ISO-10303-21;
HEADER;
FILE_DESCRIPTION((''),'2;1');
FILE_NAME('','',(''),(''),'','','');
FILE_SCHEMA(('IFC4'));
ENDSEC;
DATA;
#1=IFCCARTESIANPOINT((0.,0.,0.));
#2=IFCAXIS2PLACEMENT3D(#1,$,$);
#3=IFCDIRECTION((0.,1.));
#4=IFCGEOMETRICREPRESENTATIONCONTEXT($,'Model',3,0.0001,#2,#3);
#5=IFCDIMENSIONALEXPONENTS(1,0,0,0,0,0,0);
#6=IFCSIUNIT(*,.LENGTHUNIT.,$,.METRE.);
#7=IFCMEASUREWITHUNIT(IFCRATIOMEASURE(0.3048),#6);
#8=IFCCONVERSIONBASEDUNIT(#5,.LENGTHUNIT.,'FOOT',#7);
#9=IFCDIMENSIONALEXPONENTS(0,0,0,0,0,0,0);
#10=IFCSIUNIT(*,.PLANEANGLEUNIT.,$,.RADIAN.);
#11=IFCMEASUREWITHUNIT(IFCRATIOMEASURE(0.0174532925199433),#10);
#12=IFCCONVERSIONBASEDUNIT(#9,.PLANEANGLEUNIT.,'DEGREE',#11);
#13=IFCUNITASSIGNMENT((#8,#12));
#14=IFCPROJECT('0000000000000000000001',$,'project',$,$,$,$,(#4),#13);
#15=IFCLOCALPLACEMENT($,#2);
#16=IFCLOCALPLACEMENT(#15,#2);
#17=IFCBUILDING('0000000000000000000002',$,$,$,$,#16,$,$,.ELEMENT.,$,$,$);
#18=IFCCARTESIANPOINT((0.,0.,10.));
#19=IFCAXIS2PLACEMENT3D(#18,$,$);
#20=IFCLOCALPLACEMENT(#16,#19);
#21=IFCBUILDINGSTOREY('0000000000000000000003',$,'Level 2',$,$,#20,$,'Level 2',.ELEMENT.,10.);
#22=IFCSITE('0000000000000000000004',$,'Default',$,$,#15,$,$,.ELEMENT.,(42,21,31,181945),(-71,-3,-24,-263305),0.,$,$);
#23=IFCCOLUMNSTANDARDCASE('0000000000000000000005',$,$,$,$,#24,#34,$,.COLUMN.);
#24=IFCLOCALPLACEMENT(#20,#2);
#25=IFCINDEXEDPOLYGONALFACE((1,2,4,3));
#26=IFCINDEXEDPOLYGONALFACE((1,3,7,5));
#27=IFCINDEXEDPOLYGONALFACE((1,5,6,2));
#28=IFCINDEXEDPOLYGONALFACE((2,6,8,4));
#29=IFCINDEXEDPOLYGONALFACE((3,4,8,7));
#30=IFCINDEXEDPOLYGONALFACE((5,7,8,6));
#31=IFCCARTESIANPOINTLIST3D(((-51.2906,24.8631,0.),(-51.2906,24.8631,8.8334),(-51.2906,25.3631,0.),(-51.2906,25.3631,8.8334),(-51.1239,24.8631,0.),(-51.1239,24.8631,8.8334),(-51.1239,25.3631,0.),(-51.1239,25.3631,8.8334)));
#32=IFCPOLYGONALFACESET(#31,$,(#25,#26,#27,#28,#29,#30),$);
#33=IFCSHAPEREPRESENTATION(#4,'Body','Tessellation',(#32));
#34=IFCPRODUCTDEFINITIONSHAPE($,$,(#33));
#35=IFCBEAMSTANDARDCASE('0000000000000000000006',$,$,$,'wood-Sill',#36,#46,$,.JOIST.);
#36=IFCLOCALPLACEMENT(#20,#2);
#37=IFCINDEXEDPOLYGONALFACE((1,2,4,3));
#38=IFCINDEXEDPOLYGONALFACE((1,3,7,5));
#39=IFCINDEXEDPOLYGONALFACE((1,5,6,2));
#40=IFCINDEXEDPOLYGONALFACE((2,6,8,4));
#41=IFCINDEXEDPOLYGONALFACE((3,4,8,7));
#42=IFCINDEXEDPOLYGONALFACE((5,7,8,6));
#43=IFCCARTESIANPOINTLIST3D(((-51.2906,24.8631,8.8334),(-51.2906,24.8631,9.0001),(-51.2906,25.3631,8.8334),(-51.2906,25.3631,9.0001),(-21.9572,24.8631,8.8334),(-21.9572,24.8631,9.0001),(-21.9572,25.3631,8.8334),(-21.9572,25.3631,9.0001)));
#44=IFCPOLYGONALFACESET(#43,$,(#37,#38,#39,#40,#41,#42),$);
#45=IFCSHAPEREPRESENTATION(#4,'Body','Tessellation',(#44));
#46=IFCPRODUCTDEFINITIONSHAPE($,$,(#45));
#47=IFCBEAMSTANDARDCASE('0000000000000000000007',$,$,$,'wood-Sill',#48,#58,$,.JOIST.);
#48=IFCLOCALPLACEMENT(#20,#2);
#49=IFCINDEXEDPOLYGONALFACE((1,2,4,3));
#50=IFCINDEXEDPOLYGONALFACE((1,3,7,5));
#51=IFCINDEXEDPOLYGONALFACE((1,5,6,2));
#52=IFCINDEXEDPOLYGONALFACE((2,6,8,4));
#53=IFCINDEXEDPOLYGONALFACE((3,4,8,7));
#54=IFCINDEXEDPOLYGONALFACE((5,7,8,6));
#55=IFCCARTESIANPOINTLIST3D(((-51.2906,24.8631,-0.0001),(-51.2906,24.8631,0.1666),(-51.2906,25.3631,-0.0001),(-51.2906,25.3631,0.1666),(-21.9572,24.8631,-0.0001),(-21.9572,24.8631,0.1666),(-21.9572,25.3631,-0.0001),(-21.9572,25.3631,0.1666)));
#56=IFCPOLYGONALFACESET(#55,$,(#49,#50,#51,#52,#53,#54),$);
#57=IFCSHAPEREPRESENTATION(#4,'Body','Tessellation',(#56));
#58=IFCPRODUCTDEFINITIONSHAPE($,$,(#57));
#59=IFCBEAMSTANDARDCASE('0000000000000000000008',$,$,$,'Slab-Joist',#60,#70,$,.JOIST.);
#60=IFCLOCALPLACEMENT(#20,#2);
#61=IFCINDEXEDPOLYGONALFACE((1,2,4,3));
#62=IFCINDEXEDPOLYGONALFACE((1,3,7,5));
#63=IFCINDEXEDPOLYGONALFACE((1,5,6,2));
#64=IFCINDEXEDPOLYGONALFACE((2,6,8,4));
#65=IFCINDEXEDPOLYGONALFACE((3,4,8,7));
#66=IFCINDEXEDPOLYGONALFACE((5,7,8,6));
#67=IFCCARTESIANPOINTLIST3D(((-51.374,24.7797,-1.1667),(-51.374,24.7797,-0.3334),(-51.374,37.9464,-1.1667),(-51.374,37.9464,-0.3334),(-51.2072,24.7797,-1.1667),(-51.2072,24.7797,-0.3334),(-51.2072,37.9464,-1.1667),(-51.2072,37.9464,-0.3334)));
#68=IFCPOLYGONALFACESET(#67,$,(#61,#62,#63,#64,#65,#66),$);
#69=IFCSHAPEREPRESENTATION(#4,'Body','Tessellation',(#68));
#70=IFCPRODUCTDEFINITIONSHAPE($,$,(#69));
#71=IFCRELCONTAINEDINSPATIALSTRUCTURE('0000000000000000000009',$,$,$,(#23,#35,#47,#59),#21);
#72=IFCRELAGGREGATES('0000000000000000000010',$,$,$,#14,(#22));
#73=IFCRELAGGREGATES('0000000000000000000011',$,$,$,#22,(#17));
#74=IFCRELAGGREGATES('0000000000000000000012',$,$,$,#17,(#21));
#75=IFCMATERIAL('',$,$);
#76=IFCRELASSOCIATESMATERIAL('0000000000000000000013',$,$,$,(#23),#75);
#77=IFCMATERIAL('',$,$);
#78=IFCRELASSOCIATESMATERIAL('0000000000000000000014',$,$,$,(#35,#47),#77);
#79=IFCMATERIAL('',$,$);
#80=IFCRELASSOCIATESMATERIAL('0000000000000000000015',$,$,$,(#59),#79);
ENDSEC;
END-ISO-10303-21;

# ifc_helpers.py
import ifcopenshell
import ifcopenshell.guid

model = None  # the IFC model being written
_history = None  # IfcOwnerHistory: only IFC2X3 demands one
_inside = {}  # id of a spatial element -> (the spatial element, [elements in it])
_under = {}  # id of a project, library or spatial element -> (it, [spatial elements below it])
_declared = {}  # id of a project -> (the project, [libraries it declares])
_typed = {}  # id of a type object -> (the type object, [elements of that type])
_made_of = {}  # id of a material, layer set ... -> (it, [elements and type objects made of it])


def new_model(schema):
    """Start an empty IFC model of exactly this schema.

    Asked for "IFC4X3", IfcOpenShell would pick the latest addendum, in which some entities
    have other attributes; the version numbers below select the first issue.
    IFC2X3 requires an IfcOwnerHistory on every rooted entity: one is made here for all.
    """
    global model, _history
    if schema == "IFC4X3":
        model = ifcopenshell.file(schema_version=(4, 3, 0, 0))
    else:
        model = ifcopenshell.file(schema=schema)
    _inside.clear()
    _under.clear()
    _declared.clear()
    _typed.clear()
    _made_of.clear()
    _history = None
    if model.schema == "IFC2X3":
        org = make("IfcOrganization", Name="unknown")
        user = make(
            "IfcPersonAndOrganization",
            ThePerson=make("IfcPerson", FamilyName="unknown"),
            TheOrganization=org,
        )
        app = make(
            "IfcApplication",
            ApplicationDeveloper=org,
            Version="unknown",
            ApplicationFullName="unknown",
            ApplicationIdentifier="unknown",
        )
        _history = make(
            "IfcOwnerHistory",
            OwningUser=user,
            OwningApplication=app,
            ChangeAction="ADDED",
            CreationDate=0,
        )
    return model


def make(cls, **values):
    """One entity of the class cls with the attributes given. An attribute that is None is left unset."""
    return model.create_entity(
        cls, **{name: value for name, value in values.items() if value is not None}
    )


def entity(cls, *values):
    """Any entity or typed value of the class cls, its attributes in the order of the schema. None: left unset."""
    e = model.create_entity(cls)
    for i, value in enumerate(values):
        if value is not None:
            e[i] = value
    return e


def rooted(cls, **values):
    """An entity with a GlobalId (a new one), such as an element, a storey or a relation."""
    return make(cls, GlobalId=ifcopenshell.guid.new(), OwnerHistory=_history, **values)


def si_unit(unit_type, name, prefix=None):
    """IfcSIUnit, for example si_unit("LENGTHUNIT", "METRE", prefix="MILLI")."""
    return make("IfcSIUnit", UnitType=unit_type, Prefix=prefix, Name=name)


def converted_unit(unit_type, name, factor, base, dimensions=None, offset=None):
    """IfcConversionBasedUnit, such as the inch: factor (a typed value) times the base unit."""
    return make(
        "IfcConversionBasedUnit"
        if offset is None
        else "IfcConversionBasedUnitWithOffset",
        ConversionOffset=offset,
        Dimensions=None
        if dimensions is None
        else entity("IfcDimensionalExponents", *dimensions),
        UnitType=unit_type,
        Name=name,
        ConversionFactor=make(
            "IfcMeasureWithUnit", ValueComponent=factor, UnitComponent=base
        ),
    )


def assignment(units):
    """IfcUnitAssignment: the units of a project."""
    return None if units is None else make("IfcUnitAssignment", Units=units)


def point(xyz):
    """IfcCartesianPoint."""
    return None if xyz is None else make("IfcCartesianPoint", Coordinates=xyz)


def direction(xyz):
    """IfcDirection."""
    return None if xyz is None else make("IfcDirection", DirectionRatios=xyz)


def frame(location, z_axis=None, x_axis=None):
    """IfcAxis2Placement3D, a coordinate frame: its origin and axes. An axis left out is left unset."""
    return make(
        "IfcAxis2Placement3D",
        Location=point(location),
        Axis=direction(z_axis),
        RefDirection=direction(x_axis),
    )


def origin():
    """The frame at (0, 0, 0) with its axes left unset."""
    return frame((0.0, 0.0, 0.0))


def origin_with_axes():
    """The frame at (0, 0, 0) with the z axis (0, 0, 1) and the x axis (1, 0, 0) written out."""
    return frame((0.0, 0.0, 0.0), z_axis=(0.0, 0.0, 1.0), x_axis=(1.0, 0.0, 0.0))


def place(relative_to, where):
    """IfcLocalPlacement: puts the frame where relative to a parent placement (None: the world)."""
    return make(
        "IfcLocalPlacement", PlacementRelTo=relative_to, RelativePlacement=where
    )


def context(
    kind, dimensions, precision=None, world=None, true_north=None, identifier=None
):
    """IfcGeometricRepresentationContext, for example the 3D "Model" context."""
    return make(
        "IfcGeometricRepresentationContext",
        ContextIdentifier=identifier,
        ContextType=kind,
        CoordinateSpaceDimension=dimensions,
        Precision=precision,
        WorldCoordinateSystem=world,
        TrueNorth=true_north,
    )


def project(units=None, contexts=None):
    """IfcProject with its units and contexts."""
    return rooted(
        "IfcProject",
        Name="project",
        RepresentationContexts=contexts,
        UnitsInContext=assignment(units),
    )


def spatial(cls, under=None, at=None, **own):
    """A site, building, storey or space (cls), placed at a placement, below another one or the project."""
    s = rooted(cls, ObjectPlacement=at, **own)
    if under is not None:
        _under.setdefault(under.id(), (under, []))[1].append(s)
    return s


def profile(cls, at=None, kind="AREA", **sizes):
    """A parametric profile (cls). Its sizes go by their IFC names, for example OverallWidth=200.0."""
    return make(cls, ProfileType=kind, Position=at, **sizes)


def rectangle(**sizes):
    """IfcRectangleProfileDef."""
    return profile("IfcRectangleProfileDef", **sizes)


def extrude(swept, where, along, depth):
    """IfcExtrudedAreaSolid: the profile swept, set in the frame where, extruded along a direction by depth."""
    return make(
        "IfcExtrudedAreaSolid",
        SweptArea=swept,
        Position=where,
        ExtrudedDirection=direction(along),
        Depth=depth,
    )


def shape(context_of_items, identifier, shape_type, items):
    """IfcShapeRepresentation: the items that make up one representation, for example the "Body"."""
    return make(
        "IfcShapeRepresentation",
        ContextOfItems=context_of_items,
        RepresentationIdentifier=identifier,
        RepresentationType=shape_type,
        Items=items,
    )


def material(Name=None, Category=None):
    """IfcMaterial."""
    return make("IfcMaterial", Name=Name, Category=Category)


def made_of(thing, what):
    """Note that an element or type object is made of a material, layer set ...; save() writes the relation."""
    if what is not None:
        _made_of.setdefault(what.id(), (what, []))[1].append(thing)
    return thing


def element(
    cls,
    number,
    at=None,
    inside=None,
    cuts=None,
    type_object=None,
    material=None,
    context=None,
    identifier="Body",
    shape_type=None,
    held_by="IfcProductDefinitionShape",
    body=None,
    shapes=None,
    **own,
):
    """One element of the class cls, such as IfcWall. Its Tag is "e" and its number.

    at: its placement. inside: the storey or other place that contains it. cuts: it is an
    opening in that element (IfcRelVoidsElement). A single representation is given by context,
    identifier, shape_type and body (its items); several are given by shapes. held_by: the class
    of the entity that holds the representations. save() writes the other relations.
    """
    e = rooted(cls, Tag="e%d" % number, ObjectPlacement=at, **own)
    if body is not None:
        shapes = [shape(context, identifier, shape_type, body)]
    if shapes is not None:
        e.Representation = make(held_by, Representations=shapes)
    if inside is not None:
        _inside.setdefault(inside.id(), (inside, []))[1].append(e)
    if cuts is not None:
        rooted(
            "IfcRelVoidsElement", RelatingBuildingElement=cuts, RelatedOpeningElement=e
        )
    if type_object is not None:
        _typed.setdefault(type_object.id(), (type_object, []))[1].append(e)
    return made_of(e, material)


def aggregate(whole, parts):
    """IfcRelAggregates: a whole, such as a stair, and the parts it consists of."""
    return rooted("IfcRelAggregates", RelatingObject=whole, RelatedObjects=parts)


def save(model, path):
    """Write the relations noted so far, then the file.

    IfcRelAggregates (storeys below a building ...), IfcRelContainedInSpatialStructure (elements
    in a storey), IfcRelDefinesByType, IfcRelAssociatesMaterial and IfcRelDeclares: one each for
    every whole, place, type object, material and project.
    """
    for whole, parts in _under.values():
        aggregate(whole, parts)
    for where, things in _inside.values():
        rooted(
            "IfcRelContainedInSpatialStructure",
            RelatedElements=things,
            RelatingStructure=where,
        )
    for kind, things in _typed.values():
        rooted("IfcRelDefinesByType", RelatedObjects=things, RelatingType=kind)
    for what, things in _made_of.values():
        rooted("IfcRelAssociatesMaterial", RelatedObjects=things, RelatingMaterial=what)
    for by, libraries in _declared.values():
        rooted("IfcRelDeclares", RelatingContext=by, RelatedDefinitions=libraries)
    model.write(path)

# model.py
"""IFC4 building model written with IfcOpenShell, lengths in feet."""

from ifc_helpers import new_model, entity, si_unit, converted_unit, direction, frame, origin, origin_with_axes, place, context, project, spatial, rectangle, extrude, material, element, save


model = new_model("IFC4")

# Units and contexts
model_context = context("Model", 3, precision=0.0001, world=origin(), true_north=direction((0.0, 1.0)))
ifc_project = project(units=[converted_unit("LENGTHUNIT", "FOOT", entity("IfcRatioMeasure", 0.3048), si_unit("LENGTHUNIT", "METRE"), dimensions=[1, 0, 0, 0, 0, 0, 0]), converted_unit("PLANEANGLEUNIT", "DEGREE", entity("IfcRatioMeasure", 0.0174532925199433), si_unit("PLANEANGLEUNIT", "RADIAN"), dimensions=[0, 0, 0, 0, 0, 0, 0])], contexts=[model_context])

# Site, building, storey
site_placement = place(None, origin())
site = spatial("IfcSite", under=ifc_project, at=site_placement, Name="Default", CompositionType="ELEMENT", RefLatitude=(42, 21, 31, 181945), RefLongitude=(-71, -3, -24, -263305), RefElevation=0.0)
building_placement = place(site_placement, origin())
building = spatial("IfcBuilding", under=site, at=building_placement, CompositionType="ELEMENT")
storey_placement = place(building_placement, frame((0.0, 0.0, 10.0)))
storey = spatial("IfcBuildingStorey", under=building, at=storey_placement, Name="Level 2", LongName="Level 2", CompositionType="ELEMENT", Elevation=10.0)

# Column
ifc_material_1 = material(Name="")
placement_1 = place(storey_placement, frame((-51.2906, 25.1131, 0.0)))
for number, where, z_axis, x_axis in (
    (1, (0.0833, 0.0, 0.0), (0.0, 0.0, 1.0), (1.0, 0.0, 0.0)),
):
    element("IfcColumnStandardCase", number, at=place(placement_1, frame(where, z_axis=z_axis, x_axis=x_axis)), inside=storey, material=ifc_material_1, PredefinedType="COLUMN", context=model_context, shape_type="SweptSolid", body=[
        extrude(rectangle(XDim=0.1667, YDim=0.5), origin(), (0.0, 0.0, 1.0), 8.8334),
    ])

# Beams
ifc_material_2 = material(Name="")
for number, where, z_axis, x_axis in (
    (2, (0.0, 0.0, 8.9167), (1.0, 0.0, 0.0), (0.0, 0.0, 1.0)),
    (3, (0.0, 0.0, 0.0833), (1.0, 0.0, 0.0), (0.0, 0.0, 1.0)),
):
    element("IfcBeamStandardCase", number, at=place(placement_1, frame(where, z_axis=z_axis, x_axis=x_axis)), inside=storey, material=ifc_material_2, ObjectType="wood-Sill", PredefinedType="JOIST", context=model_context, shape_type="SweptSolid", body=[
        extrude(rectangle(XDim=0.1667, YDim=0.5), origin_with_axes(), (0.0, 0.0, 1.0), 29.3334),
    ])
ifc_material_3 = material(Name="")
placement_2 = place(storey_placement, frame((-51.2906, 24.7797, 0.0), z_axis=(0.0, 0.0, 1.0), x_axis=(1.0, 0.0, 0.0)))
beam_1_placement = place(placement_2, frame((0.0, 0.0, -0.75), z_axis=(0.0, 1.0, 0.0), x_axis=(-1.0, 0.0, 0.0)))
element("IfcBeamStandardCase", 4, at=beam_1_placement, inside=storey, material=ifc_material_3, ObjectType="Slab-Joist", PredefinedType="JOIST", context=model_context, shape_type="SweptSolid", body=[
    extrude(rectangle(XDim=0.1667, YDim=0.8333), origin_with_axes(), (0.0, 0.0, 1.0), 13.1667),
])

save(model, "model.ifc")
